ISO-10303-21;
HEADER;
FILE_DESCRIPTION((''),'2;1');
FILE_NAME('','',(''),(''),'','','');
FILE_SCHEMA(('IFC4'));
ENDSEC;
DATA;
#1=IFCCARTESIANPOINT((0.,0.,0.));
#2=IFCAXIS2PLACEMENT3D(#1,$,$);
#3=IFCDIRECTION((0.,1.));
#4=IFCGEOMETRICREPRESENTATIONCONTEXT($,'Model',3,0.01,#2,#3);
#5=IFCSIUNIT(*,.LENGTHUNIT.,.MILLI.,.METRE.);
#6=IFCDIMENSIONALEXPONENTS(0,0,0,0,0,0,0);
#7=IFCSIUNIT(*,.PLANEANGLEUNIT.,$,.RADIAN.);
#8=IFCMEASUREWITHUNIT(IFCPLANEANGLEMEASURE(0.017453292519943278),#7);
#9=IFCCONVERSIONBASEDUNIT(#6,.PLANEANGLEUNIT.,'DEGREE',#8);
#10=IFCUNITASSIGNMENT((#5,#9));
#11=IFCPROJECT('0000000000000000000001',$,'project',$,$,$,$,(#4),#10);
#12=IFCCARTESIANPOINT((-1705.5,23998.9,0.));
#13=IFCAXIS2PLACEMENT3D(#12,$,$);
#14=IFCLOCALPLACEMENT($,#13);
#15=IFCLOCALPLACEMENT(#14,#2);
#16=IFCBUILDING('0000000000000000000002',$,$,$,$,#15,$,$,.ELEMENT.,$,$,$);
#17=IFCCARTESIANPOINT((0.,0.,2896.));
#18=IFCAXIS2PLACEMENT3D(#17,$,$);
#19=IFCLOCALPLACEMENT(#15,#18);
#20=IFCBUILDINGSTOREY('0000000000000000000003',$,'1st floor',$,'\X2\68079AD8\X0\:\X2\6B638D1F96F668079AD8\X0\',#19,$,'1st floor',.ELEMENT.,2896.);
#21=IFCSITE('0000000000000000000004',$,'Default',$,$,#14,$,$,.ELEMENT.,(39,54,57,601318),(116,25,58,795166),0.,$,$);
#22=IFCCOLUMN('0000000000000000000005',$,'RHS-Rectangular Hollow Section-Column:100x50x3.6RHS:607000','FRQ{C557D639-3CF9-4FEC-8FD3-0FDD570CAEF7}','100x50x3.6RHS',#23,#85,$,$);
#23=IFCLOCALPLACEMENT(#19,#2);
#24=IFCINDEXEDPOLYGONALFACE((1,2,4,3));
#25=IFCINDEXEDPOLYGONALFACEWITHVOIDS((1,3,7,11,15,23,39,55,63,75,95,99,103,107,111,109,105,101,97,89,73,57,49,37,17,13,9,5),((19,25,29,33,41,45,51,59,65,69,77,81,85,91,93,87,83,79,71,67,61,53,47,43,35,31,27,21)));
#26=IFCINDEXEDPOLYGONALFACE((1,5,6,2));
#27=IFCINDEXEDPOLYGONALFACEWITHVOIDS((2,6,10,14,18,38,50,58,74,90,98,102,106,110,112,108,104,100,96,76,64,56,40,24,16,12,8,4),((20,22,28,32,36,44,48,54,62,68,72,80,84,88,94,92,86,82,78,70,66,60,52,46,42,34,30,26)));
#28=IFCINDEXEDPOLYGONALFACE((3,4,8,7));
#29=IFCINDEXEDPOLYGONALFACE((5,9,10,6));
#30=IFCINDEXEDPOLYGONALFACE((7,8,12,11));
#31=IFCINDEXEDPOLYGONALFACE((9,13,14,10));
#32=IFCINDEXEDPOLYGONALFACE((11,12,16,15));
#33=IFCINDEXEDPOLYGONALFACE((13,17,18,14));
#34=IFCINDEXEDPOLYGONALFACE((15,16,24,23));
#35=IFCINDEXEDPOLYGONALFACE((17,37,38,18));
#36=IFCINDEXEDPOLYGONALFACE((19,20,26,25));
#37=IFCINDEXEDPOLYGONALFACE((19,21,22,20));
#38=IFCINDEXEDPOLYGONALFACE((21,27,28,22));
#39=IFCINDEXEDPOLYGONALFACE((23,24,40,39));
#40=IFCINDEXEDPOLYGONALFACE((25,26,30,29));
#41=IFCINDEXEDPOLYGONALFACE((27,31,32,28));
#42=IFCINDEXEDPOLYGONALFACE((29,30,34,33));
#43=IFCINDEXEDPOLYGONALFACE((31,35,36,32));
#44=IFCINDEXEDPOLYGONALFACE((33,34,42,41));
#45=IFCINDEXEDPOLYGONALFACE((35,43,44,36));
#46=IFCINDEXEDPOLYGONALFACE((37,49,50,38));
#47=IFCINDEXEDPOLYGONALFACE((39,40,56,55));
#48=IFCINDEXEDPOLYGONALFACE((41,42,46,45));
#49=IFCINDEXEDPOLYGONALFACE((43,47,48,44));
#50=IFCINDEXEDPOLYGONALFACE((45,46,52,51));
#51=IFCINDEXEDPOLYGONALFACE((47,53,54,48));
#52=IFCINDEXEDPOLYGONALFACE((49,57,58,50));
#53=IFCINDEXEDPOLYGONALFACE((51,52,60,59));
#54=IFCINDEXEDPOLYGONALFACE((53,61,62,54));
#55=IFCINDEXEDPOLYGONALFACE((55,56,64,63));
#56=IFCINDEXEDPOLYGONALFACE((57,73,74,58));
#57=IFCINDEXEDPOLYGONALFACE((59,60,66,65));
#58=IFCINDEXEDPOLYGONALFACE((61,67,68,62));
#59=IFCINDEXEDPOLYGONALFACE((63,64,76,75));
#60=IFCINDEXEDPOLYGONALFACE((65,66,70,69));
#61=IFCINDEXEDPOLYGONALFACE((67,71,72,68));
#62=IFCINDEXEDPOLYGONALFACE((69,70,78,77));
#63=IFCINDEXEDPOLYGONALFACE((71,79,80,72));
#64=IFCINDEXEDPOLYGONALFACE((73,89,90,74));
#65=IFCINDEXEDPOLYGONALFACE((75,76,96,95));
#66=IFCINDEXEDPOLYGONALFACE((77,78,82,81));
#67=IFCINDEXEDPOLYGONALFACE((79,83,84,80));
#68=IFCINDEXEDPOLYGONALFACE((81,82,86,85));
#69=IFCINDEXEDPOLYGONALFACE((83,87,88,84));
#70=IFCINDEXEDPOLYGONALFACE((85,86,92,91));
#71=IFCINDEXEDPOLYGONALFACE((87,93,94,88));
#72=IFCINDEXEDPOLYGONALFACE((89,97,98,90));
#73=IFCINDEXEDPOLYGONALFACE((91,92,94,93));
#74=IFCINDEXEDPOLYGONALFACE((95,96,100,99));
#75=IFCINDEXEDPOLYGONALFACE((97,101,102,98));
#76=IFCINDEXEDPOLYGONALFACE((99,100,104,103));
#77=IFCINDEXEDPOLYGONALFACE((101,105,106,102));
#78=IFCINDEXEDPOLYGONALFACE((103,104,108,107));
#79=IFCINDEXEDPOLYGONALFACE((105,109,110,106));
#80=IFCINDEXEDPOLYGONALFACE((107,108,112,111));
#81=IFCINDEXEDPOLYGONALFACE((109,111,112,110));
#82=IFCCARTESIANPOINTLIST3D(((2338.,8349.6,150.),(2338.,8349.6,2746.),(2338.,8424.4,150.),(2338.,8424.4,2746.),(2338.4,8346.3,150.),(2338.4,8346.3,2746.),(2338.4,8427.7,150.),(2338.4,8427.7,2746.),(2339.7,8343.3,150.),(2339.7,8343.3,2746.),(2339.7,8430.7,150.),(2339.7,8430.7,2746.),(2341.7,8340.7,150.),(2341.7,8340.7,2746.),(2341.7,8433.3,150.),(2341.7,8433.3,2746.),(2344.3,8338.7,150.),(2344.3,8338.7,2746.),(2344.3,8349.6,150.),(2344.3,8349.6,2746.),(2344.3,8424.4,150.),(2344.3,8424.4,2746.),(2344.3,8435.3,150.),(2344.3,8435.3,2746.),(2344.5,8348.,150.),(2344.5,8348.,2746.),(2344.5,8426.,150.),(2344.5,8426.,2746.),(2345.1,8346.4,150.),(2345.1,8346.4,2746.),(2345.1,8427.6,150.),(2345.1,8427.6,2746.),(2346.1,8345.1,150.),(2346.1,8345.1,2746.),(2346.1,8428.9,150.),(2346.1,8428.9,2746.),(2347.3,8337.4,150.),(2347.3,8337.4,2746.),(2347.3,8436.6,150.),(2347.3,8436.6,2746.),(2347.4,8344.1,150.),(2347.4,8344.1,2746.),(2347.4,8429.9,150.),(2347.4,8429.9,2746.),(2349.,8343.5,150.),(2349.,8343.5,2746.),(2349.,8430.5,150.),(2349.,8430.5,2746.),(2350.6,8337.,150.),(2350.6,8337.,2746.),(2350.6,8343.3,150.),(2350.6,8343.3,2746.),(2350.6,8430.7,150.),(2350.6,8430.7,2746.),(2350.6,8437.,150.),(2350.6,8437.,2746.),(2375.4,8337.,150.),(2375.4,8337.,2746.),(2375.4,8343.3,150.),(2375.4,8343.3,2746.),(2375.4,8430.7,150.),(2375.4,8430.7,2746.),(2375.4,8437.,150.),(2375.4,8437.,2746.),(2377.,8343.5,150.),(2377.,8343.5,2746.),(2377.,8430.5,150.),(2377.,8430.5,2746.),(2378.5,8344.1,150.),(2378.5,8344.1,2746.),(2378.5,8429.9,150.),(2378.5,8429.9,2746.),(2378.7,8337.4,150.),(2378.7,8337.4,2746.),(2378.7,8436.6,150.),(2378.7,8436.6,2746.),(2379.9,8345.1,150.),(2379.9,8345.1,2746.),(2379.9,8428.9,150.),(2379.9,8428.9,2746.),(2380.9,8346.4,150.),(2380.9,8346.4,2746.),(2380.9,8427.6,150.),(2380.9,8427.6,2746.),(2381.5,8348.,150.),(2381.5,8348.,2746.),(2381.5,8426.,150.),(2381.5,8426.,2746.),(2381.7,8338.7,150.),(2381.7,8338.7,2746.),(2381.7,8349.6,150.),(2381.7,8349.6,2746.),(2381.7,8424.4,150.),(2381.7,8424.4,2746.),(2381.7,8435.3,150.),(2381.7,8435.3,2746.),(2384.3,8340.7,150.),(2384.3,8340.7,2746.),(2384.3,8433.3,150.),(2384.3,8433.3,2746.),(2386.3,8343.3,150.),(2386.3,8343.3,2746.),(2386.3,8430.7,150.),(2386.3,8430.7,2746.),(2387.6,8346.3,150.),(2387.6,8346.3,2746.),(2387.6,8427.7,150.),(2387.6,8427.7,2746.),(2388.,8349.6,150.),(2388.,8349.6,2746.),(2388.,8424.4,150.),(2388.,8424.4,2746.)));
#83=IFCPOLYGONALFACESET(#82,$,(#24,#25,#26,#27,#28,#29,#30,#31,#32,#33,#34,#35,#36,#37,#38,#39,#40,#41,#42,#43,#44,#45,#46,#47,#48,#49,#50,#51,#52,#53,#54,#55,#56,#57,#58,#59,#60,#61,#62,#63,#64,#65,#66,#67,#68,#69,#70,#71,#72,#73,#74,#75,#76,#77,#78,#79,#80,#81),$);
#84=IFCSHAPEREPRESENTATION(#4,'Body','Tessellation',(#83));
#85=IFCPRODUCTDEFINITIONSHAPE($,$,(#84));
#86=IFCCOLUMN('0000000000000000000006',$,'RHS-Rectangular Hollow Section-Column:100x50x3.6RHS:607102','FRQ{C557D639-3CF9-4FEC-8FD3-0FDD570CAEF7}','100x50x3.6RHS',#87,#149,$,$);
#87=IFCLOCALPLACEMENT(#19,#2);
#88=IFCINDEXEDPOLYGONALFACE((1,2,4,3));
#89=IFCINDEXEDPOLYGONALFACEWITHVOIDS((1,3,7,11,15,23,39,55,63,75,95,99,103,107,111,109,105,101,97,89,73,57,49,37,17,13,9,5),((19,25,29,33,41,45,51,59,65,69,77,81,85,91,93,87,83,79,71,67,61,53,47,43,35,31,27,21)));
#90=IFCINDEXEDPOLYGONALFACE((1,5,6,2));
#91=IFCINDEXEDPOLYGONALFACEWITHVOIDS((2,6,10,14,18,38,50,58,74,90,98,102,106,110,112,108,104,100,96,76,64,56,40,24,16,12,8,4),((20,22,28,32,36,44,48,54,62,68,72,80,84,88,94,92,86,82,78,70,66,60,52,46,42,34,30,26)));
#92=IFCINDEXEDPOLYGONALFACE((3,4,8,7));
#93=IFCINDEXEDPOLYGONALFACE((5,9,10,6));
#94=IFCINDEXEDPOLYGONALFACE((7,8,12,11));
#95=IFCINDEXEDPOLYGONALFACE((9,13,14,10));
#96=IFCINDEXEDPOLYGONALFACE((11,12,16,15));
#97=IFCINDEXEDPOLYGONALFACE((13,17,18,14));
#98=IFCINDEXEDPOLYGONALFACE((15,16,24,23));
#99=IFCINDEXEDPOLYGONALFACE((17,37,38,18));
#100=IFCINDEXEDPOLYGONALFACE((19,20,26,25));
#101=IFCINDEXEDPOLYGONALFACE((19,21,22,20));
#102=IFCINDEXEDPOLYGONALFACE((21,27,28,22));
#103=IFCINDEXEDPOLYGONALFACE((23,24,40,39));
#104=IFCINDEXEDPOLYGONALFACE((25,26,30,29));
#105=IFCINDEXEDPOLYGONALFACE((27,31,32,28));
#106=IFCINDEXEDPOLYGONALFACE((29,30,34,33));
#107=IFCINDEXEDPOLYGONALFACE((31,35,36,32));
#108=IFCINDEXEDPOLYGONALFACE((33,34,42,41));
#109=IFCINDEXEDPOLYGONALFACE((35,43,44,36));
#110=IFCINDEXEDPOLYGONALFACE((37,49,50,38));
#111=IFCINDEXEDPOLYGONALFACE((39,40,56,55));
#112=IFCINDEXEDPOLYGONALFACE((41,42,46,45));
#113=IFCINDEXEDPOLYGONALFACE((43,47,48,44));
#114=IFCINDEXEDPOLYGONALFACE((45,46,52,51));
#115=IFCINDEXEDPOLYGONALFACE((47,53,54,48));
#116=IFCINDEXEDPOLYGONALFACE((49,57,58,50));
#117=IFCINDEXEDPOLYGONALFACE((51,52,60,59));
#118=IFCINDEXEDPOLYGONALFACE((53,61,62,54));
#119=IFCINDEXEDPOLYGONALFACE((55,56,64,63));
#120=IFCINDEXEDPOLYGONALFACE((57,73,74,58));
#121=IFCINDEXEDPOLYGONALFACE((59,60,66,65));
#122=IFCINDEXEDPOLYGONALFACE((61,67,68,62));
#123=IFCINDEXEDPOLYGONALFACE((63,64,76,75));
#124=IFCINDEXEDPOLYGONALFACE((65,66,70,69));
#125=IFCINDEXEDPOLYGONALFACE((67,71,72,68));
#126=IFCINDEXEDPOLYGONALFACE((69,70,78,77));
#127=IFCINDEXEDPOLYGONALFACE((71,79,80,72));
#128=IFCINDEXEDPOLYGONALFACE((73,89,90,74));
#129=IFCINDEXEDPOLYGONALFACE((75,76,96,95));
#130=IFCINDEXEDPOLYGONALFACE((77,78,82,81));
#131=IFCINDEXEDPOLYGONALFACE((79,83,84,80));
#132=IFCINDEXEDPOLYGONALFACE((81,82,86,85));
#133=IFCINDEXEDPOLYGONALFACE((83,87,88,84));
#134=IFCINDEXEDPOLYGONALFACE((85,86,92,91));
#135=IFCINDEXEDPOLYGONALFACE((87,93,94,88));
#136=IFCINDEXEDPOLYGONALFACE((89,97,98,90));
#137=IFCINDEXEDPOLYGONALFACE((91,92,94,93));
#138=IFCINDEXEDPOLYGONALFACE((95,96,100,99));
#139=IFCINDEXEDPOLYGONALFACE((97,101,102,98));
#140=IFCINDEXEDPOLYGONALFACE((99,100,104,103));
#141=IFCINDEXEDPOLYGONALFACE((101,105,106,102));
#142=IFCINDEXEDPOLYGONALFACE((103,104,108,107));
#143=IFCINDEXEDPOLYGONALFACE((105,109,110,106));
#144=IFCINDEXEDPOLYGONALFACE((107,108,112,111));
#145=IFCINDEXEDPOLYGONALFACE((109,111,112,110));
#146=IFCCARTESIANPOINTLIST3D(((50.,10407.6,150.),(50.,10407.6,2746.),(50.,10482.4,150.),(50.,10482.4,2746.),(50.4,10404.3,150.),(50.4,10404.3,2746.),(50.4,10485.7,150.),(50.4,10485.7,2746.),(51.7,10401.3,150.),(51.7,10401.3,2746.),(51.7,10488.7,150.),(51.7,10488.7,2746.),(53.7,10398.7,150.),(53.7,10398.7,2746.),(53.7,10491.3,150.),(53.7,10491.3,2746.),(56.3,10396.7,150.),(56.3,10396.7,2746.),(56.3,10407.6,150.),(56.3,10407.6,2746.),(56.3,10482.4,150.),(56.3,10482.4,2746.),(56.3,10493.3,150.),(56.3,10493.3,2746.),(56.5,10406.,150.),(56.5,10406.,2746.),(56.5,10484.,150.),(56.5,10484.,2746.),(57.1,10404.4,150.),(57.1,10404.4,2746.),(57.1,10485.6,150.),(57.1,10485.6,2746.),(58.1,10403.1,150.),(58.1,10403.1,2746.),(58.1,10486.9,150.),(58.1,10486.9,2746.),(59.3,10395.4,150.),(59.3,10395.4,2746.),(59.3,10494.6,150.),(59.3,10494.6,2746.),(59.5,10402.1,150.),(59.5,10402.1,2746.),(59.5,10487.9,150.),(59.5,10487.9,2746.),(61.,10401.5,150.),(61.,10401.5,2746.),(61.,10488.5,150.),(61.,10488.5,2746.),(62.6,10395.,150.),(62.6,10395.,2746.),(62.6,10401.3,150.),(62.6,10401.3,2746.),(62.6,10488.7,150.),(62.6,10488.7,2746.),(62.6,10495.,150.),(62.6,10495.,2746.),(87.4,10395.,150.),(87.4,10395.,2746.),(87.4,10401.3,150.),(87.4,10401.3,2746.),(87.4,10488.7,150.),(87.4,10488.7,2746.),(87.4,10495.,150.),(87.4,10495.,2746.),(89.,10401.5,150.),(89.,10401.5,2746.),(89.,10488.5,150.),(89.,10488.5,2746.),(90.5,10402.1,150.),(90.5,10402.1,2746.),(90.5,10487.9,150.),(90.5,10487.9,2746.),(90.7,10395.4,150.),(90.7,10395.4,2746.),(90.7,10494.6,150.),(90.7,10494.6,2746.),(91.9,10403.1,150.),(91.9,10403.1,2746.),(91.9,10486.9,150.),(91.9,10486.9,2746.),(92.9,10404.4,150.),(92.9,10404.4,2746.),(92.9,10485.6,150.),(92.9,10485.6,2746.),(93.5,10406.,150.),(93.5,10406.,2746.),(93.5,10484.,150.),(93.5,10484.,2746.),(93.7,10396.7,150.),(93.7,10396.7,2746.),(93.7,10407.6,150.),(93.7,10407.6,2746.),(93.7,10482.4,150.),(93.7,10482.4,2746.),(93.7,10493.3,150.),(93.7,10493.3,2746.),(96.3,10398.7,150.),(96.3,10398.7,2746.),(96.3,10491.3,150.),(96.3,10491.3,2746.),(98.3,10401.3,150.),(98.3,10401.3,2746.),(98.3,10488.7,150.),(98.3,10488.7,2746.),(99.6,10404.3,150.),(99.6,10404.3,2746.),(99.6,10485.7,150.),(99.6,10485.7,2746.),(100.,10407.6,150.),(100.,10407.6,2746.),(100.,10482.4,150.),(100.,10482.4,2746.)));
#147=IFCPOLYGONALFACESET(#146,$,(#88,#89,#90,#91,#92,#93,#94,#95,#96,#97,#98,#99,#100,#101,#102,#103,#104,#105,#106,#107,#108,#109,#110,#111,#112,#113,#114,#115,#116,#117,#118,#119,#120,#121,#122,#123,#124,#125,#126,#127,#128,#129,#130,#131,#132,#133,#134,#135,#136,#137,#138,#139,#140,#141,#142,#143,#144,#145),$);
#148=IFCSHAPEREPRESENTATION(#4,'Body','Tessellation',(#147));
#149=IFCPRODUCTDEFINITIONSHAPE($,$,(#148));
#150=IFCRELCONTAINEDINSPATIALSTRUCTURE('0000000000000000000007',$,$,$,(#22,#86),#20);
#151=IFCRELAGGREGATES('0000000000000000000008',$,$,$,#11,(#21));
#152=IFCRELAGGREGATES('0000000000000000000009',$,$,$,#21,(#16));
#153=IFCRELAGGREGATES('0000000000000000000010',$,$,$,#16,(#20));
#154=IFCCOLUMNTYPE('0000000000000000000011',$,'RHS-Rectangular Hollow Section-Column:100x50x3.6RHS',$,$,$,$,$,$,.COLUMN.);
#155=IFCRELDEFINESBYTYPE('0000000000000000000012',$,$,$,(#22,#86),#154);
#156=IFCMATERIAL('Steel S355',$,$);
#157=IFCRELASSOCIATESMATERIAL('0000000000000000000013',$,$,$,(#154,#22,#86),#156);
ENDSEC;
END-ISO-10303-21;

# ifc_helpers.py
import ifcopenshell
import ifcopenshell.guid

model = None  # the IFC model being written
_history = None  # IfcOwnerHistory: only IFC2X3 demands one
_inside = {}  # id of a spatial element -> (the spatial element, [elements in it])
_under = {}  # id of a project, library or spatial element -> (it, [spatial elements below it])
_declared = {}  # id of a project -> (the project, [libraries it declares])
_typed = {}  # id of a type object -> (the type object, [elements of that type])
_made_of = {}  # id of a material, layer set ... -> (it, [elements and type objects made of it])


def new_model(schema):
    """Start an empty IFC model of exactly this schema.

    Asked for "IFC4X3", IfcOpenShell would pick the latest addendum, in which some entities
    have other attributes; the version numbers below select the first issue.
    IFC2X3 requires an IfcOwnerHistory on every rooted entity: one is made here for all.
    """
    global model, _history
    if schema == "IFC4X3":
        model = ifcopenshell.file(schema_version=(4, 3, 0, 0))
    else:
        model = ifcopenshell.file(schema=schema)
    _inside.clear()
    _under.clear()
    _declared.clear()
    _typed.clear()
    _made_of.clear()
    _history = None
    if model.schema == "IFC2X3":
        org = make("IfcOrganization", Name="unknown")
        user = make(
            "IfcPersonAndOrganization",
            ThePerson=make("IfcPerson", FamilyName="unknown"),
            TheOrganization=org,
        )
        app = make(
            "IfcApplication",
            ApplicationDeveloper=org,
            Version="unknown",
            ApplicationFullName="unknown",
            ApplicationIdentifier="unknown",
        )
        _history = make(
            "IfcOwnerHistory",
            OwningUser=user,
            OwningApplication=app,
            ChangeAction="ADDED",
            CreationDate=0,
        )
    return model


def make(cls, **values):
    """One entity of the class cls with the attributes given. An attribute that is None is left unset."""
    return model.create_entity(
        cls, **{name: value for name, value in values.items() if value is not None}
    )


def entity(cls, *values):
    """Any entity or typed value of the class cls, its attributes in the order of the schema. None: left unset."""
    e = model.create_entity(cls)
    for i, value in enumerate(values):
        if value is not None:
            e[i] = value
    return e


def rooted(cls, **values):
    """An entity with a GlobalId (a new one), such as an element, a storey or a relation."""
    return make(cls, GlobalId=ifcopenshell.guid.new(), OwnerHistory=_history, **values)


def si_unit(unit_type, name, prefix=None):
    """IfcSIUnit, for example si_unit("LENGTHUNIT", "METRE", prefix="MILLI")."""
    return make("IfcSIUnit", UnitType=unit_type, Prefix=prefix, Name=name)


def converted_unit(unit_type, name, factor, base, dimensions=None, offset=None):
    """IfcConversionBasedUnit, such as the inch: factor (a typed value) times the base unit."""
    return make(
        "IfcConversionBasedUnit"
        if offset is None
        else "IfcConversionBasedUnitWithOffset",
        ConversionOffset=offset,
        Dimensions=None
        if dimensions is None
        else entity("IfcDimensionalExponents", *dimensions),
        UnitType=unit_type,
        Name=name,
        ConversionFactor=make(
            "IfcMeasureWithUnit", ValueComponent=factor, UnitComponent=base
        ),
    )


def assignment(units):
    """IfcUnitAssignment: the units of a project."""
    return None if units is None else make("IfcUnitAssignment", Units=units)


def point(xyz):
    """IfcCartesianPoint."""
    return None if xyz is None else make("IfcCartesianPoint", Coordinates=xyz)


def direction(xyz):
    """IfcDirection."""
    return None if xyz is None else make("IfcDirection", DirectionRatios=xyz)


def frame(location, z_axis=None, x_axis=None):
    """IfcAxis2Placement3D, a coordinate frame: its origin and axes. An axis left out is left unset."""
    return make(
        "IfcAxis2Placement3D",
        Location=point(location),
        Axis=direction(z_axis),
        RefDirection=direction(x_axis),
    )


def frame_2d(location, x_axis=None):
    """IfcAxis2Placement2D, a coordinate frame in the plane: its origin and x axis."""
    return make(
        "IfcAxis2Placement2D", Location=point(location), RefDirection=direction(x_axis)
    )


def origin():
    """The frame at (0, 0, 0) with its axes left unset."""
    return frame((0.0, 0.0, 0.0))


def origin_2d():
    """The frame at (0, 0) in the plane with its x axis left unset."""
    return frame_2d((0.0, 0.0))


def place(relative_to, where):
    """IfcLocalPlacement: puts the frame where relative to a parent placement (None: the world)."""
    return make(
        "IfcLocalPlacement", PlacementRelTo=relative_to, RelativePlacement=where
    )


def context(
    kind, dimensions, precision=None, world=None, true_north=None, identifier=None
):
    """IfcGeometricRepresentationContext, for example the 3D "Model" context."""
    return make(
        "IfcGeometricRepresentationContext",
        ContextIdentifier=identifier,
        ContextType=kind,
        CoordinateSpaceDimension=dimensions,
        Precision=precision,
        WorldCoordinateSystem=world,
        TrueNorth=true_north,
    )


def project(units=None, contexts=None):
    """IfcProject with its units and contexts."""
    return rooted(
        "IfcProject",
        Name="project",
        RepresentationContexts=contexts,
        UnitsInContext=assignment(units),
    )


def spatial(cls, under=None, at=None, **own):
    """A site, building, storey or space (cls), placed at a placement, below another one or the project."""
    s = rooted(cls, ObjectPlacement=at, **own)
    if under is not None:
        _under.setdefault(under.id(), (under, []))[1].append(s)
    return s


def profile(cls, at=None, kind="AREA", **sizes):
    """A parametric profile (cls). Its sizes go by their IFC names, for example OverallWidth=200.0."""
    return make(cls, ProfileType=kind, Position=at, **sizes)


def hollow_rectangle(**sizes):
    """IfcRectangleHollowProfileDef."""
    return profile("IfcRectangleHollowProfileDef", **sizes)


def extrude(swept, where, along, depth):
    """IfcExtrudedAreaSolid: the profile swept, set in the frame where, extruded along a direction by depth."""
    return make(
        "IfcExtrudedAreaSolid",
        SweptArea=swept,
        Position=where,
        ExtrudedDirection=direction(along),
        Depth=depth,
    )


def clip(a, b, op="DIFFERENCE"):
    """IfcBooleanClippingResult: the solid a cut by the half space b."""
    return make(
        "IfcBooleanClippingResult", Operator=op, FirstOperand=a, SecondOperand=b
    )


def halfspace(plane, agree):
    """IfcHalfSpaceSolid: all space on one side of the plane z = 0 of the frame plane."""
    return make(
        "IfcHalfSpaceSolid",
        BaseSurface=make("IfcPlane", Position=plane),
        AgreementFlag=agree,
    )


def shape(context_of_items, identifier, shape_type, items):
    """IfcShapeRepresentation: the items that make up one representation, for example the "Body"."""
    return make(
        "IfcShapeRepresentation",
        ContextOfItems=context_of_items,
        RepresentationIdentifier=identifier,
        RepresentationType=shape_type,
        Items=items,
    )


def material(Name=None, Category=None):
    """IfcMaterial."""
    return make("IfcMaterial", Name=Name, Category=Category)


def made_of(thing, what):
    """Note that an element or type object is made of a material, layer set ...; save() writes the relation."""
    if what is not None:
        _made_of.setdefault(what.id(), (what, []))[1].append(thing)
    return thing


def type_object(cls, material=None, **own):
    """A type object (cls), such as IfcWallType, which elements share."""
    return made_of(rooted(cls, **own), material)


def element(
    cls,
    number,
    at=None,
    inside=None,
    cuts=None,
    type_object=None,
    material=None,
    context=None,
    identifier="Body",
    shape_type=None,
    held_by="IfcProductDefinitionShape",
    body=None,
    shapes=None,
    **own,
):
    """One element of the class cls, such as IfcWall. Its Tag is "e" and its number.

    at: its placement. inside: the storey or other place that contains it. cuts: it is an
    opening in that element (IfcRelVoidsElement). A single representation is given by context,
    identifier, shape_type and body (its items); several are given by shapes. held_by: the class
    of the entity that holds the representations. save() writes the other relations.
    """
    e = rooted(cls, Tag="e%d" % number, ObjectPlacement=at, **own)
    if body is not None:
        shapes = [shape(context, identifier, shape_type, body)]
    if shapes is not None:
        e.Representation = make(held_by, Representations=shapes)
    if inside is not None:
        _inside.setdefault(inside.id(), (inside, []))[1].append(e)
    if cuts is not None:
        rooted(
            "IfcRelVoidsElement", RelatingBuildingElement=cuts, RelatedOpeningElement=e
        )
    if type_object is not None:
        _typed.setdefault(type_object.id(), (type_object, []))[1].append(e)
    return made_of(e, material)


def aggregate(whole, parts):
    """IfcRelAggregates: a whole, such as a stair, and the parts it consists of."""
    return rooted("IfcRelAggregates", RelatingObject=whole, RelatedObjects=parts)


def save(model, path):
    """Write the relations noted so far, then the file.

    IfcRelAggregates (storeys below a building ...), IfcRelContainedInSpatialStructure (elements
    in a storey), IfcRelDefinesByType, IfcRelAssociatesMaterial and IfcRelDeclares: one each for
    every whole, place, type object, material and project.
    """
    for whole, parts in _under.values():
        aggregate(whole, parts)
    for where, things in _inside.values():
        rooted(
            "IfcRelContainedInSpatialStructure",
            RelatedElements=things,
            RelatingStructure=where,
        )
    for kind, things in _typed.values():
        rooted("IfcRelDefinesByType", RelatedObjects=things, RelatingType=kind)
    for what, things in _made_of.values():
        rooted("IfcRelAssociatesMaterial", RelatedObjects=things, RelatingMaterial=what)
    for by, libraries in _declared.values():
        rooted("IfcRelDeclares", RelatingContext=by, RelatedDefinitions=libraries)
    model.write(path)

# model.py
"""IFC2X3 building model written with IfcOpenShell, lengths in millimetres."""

from ifc_helpers import new_model, entity, si_unit, converted_unit, direction, frame, origin, origin_2d, place, context, project, spatial, hollow_rectangle, extrude, clip, halfspace, material, type_object, element, save


model = new_model("IFC2X3")

# Units and contexts
model_context = context("Model", 3, precision=0.01, world=origin(), true_north=direction((0.0, 1.0)))
ifc_project = project(units=[si_unit("LENGTHUNIT", "METRE", prefix="MILLI"), converted_unit("PLANEANGLEUNIT", "DEGREE", entity("IfcPlaneAngleMeasure", 0.017453292519943278), si_unit("PLANEANGLEUNIT", "RADIAN"), dimensions=[0, 0, 0, 0, 0, 0, 0])], contexts=[model_context])

# Site, building, storey
site_placement = place(None, frame((-1705.5, 23998.9, 0.0)))
site = spatial("IfcSite", under=ifc_project, at=site_placement, Name="Default", CompositionType="ELEMENT", RefLatitude=(39, 54, 57, 601318), RefLongitude=(116, 25, 58, 795166), RefElevation=0.0)
building_placement = place(site_placement, origin())
building = spatial("IfcBuilding", under=site, at=building_placement, CompositionType="ELEMENT")
storey_placement = place(building_placement, frame((0.0, 0.0, 2896.0)))
storey = spatial("IfcBuildingStorey", under=building, at=storey_placement, Name="1st floor", ObjectType="标高:正负零标高", LongName="1st floor", CompositionType="ELEMENT", Elevation=2896.0)

# Columns
ifc_material_1 = material(Name="Steel S355")
column_type = type_object("IfcColumnType", Name="RHS-Rectangular Hollow Section-Column:100x50x3.6RHS", PredefinedType="COLUMN", material=ifc_material_1)
column_1_placement = place(storey_placement, frame((2363.0, 8387.0, 2746.0), z_axis=(0.0, 0.0, 1.0), x_axis=(-1.0, 0.0, 0.0)))
element("IfcColumn", 1, at=column_1_placement, inside=storey, type_object=column_type, material=ifc_material_1, Name="RHS-Rectangular Hollow Section-Column:100x50x3.6RHS:607000", Description="FRQ{C557D639-3CF9-4FEC-8FD3-0FDD570CAEF7}", ObjectType="100x50x3.6RHS", context=model_context, shape_type="Clipping", body=[
    clip(extrude(hollow_rectangle(XDim=50.0, YDim=100.0, WallThickness=6.3, InnerFilletRadius=6.3, OuterFilletRadius=12.6, at=origin_2d()), origin(), (0.0, 0.0, -1.0), 2651.9), halfspace(frame((2363.0, 8387.0, -2596.0), z_axis=(0.0, 0.0, 1.0), x_axis=(-1.0, 0.0, 0.0)), True)),
])
column_2_placement = place(storey_placement, frame((75.0, 10445.0, 2746.0), z_axis=(0.0, 0.0, 1.0), x_axis=(-1.0, 0.0, 0.0)))
element("IfcColumn", 2, at=column_2_placement, inside=storey, type_object=column_type, material=ifc_material_1, Name="RHS-Rectangular Hollow Section-Column:100x50x3.6RHS:607102", Description="FRQ{C557D639-3CF9-4FEC-8FD3-0FDD570CAEF7}", ObjectType="100x50x3.6RHS", context=model_context, shape_type="Clipping", body=[
    clip(extrude(hollow_rectangle(XDim=50.0, YDim=100.0, WallThickness=6.3, InnerFilletRadius=6.3, OuterFilletRadius=12.6, at=origin_2d()), origin(), (0.0, 0.0, -1.0), 2651.9), halfspace(frame((75.0, 10445.0, -2596.0), z_axis=(0.0, 0.0, 1.0), x_axis=(-1.0, 0.0, 0.0)), True)),
])

save(model, "model.ifc")
